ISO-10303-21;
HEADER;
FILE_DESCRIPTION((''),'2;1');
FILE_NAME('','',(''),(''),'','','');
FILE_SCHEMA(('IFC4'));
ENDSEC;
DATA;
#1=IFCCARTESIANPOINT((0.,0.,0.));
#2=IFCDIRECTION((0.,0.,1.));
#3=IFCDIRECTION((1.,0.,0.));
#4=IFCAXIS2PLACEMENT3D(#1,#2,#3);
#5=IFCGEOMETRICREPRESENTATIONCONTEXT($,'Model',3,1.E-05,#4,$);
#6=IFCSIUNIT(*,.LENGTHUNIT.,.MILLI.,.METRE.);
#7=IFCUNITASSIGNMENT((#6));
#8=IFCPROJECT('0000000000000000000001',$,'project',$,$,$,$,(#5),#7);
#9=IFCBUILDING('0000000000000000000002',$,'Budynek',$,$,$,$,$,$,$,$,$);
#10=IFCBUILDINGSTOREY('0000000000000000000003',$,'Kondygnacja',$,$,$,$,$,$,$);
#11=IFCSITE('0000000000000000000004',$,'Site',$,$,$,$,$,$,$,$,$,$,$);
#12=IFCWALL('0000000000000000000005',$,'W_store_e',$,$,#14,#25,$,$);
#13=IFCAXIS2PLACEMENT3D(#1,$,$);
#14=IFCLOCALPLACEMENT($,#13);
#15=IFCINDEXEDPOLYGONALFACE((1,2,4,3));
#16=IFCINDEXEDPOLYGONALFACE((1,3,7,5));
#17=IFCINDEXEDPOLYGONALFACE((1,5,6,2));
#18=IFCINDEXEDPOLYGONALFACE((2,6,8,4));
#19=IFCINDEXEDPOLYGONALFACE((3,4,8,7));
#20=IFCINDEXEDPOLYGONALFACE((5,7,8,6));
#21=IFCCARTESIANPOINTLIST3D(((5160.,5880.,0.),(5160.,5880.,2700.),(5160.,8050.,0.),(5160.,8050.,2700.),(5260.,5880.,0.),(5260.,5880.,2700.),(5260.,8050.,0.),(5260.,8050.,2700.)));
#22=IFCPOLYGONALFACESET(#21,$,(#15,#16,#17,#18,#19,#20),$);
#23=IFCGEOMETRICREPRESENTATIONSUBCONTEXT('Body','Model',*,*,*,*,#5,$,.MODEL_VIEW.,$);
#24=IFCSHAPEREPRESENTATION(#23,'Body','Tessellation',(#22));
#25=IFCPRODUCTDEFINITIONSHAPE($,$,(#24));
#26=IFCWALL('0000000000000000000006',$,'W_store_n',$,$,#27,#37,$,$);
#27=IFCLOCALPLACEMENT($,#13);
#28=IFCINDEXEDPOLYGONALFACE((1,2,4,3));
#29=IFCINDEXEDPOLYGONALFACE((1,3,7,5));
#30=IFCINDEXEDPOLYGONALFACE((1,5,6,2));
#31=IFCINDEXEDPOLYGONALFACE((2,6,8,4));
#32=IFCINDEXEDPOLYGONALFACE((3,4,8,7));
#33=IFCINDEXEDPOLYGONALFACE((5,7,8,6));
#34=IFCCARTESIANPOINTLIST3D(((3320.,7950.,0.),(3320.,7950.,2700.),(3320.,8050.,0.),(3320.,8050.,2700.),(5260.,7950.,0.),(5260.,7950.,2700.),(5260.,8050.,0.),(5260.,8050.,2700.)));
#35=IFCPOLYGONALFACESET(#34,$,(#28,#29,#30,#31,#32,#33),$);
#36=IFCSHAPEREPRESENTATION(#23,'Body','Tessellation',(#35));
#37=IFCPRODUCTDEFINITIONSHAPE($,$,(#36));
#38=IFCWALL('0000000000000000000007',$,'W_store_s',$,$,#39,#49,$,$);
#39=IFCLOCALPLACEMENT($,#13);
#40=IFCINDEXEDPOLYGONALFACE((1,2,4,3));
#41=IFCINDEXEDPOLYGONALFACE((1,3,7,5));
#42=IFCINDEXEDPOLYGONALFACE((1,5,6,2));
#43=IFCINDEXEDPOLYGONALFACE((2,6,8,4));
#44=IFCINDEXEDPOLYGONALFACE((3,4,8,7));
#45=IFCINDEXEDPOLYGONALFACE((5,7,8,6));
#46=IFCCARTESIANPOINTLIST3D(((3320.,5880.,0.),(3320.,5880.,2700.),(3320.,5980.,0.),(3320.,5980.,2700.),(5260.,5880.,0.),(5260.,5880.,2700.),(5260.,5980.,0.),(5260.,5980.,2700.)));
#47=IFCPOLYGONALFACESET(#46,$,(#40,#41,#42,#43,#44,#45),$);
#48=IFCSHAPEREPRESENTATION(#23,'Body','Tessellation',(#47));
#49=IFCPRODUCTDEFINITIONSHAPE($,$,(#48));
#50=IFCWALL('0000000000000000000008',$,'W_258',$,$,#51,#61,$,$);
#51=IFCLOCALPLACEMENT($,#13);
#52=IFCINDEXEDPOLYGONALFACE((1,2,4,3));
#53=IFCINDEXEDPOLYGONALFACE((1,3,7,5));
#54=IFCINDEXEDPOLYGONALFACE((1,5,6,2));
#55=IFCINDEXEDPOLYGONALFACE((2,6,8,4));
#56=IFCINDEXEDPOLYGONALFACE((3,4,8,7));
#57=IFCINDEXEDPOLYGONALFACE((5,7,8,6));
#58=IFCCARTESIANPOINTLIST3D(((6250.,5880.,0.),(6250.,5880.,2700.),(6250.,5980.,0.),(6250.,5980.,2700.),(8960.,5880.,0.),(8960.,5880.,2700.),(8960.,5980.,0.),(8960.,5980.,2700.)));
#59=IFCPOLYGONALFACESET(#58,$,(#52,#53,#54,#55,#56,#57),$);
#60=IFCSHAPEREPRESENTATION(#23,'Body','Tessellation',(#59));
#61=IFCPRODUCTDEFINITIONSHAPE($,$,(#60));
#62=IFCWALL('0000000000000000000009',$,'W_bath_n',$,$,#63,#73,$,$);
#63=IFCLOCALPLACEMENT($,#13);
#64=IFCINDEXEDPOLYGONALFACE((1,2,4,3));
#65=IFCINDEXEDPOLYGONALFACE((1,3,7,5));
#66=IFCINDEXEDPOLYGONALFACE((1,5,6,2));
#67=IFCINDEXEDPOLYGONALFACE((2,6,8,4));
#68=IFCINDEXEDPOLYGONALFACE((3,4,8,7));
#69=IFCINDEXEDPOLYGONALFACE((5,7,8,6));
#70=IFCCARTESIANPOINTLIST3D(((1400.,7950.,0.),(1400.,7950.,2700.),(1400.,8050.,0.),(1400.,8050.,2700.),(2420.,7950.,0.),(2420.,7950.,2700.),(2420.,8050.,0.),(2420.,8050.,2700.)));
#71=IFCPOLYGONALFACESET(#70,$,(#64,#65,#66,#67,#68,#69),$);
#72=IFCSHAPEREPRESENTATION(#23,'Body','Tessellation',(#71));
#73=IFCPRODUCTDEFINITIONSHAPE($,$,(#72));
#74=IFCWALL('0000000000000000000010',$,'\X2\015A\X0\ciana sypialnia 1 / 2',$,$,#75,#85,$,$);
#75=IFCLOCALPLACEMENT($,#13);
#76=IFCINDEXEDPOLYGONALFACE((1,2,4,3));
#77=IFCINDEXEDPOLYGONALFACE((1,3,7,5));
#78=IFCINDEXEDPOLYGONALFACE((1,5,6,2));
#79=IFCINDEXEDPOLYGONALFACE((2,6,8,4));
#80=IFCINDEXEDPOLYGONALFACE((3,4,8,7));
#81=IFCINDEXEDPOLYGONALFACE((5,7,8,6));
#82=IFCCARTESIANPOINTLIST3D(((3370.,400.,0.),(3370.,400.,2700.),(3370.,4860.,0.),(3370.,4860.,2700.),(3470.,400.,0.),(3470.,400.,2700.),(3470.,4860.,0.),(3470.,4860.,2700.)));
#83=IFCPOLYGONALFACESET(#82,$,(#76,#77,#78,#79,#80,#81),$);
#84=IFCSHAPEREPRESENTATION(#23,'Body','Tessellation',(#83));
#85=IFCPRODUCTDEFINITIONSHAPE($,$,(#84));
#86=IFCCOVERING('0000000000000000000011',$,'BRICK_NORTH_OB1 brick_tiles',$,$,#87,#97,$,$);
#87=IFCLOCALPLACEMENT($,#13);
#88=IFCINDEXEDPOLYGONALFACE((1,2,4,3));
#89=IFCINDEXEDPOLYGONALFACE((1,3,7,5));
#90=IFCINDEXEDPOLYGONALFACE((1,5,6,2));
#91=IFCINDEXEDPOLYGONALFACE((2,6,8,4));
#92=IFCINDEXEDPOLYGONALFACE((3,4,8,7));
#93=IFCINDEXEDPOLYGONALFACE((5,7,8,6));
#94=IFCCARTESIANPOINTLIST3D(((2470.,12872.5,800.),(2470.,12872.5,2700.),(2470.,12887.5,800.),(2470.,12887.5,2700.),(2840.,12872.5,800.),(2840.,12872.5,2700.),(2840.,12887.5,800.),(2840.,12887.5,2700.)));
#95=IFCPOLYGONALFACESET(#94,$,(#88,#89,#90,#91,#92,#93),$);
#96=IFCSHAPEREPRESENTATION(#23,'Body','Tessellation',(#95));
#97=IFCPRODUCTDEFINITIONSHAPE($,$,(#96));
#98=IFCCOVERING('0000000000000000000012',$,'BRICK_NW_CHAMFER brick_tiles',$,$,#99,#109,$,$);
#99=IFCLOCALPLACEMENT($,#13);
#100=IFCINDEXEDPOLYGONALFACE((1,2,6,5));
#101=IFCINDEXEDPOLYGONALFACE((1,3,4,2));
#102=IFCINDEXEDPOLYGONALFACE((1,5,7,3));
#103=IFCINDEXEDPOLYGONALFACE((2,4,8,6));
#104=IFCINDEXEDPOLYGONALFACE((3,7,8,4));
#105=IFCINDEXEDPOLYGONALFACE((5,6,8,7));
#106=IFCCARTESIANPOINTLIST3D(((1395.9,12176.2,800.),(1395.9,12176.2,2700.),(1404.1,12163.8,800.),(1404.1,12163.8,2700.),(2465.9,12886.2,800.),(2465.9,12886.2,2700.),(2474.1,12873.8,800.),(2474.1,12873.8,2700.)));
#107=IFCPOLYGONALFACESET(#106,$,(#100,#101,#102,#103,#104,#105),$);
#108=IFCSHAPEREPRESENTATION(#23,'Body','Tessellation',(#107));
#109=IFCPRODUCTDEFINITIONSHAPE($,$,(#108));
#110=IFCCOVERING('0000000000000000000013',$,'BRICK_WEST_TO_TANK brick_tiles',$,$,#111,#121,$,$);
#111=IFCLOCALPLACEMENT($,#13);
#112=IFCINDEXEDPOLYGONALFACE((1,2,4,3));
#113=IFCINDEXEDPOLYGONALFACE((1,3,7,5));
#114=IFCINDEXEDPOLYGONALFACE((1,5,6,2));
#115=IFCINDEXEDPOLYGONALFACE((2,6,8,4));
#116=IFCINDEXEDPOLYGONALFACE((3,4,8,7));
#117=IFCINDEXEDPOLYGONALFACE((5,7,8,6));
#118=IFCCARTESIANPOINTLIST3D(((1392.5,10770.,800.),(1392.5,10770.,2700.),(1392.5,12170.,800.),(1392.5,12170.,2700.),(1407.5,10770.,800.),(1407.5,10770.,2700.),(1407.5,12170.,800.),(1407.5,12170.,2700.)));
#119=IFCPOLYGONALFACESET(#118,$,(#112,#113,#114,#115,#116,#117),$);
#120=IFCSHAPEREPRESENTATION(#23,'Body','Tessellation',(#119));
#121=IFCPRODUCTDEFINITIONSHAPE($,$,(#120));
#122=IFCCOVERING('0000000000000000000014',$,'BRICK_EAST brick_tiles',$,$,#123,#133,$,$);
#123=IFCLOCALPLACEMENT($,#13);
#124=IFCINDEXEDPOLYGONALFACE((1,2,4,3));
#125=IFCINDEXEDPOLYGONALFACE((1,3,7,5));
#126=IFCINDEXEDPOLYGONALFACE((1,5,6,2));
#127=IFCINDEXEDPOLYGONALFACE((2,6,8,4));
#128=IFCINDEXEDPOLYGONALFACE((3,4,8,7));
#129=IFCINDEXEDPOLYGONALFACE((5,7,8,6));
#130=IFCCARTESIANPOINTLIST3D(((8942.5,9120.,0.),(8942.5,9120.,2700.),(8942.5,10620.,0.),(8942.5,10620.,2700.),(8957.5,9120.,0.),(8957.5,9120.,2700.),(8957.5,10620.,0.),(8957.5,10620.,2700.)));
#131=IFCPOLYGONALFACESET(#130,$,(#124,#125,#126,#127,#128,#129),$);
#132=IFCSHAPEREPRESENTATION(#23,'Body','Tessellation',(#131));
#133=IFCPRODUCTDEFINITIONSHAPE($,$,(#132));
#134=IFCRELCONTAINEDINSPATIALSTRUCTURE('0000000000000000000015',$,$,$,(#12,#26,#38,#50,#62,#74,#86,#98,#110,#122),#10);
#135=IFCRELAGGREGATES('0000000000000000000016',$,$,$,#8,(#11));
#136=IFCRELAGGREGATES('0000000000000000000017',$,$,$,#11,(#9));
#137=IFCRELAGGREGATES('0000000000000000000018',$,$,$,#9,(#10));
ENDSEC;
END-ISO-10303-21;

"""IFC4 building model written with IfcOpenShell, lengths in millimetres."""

from ifc_helpers import new_model, si_unit, frame, origin_with_axes, place, context, subcontext, project, spatial, indexed_curve, outline, extrude, element, save


model = new_model("IFC4")

# Units and contexts
model_context = context("Model", 3, precision=1e-05, world=origin_with_axes())
body_context = subcontext(model_context, "Body", "Model", "MODEL_VIEW")
ifc_project = project(units=[si_unit("LENGTHUNIT", "METRE", prefix="MILLI")], contexts=[model_context])

# Site, building, storey
site = spatial("IfcSite", under=ifc_project, Name="Site")
building = spatial("IfcBuilding", under=site, Name="Budynek")
storey = spatial("IfcBuildingStorey", under=building, Name="Kondygnacja")

# Walls
wall_1_placement = place(None, frame((5210.0, 5880.0, 0.0), z_axis=(0.0, 0.0, 1.0), x_axis=(0.0, 1.0, 0.0)))
element("IfcWall", 1, at=wall_1_placement, inside=storey, Name="W_store_e", context=body_context, shape_type="SweptSolid", body=[
    extrude(outline(indexed_curve([(0.0, 0.0), (0.0, 100.0), (2170.0, 100.0), (2170.0, 0.0), (0.0, 0.0)], self_intersect=False)), frame((0.0, -50.0, 0.0), z_axis=(0.0, 0.0, 1.0), x_axis=(1.0, 0.0, 0.0)), (0.0, 0.0, 1.0), 2700.0),
])
for number, where, z_axis, x_axis, name in (
    (2, (3320.0, 8000.0, 0.0), (0.0, 0.0, 1.0), (1.0, 0.0, 0.0), "W_store_n"),
    (3, (3320.0, 5930.0, 0.0), (0.0, 0.0, 1.0), (1.0, 0.0, 0.0), "W_store_s"),
):
    element("IfcWall", number, at=place(None, frame(where, z_axis=z_axis, x_axis=x_axis)), inside=storey, Name=name, context=body_context, shape_type="SweptSolid", body=[
        extrude(outline(indexed_curve([(0.0, 0.0), (0.0, 100.0), (1940.0, 100.0), (1940.0, 0.0), (0.0, 0.0)], self_intersect=False)), frame((0.0, -50.0, 0.0), z_axis=(0.0, 0.0, 1.0), x_axis=(1.0, 0.0, 0.0)), (0.0, 0.0, 1.0), 2700.0),
    ])
wall_2_placement = place(None, frame((6250.0, 5930.0, 0.0), z_axis=(0.0, 0.0, 1.0), x_axis=(1.0, 0.0, 0.0)))
element("IfcWall", 4, at=wall_2_placement, inside=storey, Name="W_258", context=body_context, shape_type="SweptSolid", body=[
    extrude(outline(indexed_curve([(0.0, 0.0), (0.0, 100.0), (2710.0, 100.0), (2710.0, 0.0), (0.0, 0.0)], self_intersect=False)), frame((0.0, -50.0, 0.0), z_axis=(0.0, 0.0, 1.0), x_axis=(1.0, 0.0, 0.0)), (0.0, 0.0, 1.0), 2700.0),
])
wall_3_placement = place(None, frame((1400.0, 8000.0, 0.0), z_axis=(0.0, 0.0, 1.0), x_axis=(1.0, 0.0, 0.0)))
element("IfcWall", 5, at=wall_3_placement, inside=storey, Name="W_bath_n", context=body_context, shape_type="SweptSolid", body=[
    extrude(outline(indexed_curve([(0.0, 0.0), (0.0, 100.0), (1020.0, 100.0), (1020.0, 0.0), (0.0, 0.0)], self_intersect=False)), frame((0.0, -50.0, 0.0), z_axis=(0.0, 0.0, 1.0), x_axis=(1.0, 0.0, 0.0)), (0.0, 0.0, 1.0), 2700.0),
])
wall_4_placement = place(None, frame((3420.0, 400.0, 0.0), z_axis=(0.0, 0.0, 1.0), x_axis=(0.0, 1.0, 0.0)))
element("IfcWall", 6, at=wall_4_placement, inside=storey, Name="Ściana sypialnia 1 / 2", context=body_context, shape_type="SweptSolid", body=[
    extrude(outline(indexed_curve([(0.0, 0.0), (0.0, 100.0), (4460.0, 100.0), (4460.0, 0.0), (0.0, 0.0)], self_intersect=False)), frame((0.0, -50.0, 0.0), z_axis=(0.0, 0.0, 1.0), x_axis=(1.0, 0.0, 0.0)), (0.0, 0.0, 1.0), 2700.0),
])

# Coverings
covering_1_placement = place(None, frame((2840.0, 12880.0, 800.0), z_axis=(0.0, 0.0, 1.0), x_axis=(-1.0, 0.0, 0.0)))
element("IfcCovering", 7, at=covering_1_placement, inside=storey, Name="BRICK_NORTH_OB1 brick_tiles", context=body_context, shape_type="SweptSolid", body=[
    extrude(outline(indexed_curve([(0.0, 0.0), (0.0, 15.0), (370.0, 15.0), (370.0, 0.0), (0.0, 0.0)], self_intersect=False)), frame((0.0, -7.5, 0.0), z_axis=(0.0, 0.0, 1.0), x_axis=(1.0, 0.0, 0.0)), (0.0, 0.0, 1.0), 1900.0),
])
covering_2_placement = place(None, frame((2470.0, 12880.0, 800.0), z_axis=(0.0, 0.0, 1.0), x_axis=(-0.833246, -0.552902, 0.0)))
element("IfcCovering", 8, at=covering_2_placement, inside=storey, Name="BRICK_NW_CHAMFER brick_tiles", context=body_context, shape_type="SweptSolid", body=[
    extrude(outline(indexed_curve([(0.0, 0.0), (0.0, 15.0), (1284.1, 15.0), (1284.1, 0.0), (0.0, 0.0)], self_intersect=False)), frame((0.0, -7.5, 0.0), z_axis=(0.0, 0.0, 1.0), x_axis=(1.0, 0.0, 0.0)), (0.0, 0.0, 1.0), 1900.0),
])
covering_3_placement = place(None, frame((1400.0, 12170.0, 800.0), z_axis=(0.0, 0.0, 1.0), x_axis=(0.0, -1.0, 0.0)))
element("IfcCovering", 9, at=covering_3_placement, inside=storey, Name="BRICK_WEST_TO_TANK brick_tiles", context=body_context, shape_type="SweptSolid", body=[
    extrude(outline(indexed_curve([(0.0, 0.0), (0.0, 15.0), (1400.0, 15.0), (1400.0, 0.0), (0.0, 0.0)], self_intersect=False)), frame((0.0, -7.5, 0.0), z_axis=(0.0, 0.0, 1.0), x_axis=(1.0, 0.0, 0.0)), (0.0, 0.0, 1.0), 1900.0),
])
covering_4_placement = place(None, frame((8950.0, 9120.0, 0.0), z_axis=(0.0, 0.0, 1.0), x_axis=(0.0, 1.0, 0.0)))
element("IfcCovering", 10, at=covering_4_placement, inside=storey, Name="BRICK_EAST brick_tiles", context=body_context, shape_type="SweptSolid", body=[
    extrude(outline(indexed_curve([(0.0, 0.0), (0.0, 15.0), (1500.0, 15.0), (1500.0, 0.0), (0.0, 0.0)], self_intersect=False)), frame((0.0, -7.5, 0.0), z_axis=(0.0, 0.0, 1.0), x_axis=(1.0, 0.0, 0.0)), (0.0, 0.0, 1.0), 2700.0),
])

save(model, "model.ifc")
